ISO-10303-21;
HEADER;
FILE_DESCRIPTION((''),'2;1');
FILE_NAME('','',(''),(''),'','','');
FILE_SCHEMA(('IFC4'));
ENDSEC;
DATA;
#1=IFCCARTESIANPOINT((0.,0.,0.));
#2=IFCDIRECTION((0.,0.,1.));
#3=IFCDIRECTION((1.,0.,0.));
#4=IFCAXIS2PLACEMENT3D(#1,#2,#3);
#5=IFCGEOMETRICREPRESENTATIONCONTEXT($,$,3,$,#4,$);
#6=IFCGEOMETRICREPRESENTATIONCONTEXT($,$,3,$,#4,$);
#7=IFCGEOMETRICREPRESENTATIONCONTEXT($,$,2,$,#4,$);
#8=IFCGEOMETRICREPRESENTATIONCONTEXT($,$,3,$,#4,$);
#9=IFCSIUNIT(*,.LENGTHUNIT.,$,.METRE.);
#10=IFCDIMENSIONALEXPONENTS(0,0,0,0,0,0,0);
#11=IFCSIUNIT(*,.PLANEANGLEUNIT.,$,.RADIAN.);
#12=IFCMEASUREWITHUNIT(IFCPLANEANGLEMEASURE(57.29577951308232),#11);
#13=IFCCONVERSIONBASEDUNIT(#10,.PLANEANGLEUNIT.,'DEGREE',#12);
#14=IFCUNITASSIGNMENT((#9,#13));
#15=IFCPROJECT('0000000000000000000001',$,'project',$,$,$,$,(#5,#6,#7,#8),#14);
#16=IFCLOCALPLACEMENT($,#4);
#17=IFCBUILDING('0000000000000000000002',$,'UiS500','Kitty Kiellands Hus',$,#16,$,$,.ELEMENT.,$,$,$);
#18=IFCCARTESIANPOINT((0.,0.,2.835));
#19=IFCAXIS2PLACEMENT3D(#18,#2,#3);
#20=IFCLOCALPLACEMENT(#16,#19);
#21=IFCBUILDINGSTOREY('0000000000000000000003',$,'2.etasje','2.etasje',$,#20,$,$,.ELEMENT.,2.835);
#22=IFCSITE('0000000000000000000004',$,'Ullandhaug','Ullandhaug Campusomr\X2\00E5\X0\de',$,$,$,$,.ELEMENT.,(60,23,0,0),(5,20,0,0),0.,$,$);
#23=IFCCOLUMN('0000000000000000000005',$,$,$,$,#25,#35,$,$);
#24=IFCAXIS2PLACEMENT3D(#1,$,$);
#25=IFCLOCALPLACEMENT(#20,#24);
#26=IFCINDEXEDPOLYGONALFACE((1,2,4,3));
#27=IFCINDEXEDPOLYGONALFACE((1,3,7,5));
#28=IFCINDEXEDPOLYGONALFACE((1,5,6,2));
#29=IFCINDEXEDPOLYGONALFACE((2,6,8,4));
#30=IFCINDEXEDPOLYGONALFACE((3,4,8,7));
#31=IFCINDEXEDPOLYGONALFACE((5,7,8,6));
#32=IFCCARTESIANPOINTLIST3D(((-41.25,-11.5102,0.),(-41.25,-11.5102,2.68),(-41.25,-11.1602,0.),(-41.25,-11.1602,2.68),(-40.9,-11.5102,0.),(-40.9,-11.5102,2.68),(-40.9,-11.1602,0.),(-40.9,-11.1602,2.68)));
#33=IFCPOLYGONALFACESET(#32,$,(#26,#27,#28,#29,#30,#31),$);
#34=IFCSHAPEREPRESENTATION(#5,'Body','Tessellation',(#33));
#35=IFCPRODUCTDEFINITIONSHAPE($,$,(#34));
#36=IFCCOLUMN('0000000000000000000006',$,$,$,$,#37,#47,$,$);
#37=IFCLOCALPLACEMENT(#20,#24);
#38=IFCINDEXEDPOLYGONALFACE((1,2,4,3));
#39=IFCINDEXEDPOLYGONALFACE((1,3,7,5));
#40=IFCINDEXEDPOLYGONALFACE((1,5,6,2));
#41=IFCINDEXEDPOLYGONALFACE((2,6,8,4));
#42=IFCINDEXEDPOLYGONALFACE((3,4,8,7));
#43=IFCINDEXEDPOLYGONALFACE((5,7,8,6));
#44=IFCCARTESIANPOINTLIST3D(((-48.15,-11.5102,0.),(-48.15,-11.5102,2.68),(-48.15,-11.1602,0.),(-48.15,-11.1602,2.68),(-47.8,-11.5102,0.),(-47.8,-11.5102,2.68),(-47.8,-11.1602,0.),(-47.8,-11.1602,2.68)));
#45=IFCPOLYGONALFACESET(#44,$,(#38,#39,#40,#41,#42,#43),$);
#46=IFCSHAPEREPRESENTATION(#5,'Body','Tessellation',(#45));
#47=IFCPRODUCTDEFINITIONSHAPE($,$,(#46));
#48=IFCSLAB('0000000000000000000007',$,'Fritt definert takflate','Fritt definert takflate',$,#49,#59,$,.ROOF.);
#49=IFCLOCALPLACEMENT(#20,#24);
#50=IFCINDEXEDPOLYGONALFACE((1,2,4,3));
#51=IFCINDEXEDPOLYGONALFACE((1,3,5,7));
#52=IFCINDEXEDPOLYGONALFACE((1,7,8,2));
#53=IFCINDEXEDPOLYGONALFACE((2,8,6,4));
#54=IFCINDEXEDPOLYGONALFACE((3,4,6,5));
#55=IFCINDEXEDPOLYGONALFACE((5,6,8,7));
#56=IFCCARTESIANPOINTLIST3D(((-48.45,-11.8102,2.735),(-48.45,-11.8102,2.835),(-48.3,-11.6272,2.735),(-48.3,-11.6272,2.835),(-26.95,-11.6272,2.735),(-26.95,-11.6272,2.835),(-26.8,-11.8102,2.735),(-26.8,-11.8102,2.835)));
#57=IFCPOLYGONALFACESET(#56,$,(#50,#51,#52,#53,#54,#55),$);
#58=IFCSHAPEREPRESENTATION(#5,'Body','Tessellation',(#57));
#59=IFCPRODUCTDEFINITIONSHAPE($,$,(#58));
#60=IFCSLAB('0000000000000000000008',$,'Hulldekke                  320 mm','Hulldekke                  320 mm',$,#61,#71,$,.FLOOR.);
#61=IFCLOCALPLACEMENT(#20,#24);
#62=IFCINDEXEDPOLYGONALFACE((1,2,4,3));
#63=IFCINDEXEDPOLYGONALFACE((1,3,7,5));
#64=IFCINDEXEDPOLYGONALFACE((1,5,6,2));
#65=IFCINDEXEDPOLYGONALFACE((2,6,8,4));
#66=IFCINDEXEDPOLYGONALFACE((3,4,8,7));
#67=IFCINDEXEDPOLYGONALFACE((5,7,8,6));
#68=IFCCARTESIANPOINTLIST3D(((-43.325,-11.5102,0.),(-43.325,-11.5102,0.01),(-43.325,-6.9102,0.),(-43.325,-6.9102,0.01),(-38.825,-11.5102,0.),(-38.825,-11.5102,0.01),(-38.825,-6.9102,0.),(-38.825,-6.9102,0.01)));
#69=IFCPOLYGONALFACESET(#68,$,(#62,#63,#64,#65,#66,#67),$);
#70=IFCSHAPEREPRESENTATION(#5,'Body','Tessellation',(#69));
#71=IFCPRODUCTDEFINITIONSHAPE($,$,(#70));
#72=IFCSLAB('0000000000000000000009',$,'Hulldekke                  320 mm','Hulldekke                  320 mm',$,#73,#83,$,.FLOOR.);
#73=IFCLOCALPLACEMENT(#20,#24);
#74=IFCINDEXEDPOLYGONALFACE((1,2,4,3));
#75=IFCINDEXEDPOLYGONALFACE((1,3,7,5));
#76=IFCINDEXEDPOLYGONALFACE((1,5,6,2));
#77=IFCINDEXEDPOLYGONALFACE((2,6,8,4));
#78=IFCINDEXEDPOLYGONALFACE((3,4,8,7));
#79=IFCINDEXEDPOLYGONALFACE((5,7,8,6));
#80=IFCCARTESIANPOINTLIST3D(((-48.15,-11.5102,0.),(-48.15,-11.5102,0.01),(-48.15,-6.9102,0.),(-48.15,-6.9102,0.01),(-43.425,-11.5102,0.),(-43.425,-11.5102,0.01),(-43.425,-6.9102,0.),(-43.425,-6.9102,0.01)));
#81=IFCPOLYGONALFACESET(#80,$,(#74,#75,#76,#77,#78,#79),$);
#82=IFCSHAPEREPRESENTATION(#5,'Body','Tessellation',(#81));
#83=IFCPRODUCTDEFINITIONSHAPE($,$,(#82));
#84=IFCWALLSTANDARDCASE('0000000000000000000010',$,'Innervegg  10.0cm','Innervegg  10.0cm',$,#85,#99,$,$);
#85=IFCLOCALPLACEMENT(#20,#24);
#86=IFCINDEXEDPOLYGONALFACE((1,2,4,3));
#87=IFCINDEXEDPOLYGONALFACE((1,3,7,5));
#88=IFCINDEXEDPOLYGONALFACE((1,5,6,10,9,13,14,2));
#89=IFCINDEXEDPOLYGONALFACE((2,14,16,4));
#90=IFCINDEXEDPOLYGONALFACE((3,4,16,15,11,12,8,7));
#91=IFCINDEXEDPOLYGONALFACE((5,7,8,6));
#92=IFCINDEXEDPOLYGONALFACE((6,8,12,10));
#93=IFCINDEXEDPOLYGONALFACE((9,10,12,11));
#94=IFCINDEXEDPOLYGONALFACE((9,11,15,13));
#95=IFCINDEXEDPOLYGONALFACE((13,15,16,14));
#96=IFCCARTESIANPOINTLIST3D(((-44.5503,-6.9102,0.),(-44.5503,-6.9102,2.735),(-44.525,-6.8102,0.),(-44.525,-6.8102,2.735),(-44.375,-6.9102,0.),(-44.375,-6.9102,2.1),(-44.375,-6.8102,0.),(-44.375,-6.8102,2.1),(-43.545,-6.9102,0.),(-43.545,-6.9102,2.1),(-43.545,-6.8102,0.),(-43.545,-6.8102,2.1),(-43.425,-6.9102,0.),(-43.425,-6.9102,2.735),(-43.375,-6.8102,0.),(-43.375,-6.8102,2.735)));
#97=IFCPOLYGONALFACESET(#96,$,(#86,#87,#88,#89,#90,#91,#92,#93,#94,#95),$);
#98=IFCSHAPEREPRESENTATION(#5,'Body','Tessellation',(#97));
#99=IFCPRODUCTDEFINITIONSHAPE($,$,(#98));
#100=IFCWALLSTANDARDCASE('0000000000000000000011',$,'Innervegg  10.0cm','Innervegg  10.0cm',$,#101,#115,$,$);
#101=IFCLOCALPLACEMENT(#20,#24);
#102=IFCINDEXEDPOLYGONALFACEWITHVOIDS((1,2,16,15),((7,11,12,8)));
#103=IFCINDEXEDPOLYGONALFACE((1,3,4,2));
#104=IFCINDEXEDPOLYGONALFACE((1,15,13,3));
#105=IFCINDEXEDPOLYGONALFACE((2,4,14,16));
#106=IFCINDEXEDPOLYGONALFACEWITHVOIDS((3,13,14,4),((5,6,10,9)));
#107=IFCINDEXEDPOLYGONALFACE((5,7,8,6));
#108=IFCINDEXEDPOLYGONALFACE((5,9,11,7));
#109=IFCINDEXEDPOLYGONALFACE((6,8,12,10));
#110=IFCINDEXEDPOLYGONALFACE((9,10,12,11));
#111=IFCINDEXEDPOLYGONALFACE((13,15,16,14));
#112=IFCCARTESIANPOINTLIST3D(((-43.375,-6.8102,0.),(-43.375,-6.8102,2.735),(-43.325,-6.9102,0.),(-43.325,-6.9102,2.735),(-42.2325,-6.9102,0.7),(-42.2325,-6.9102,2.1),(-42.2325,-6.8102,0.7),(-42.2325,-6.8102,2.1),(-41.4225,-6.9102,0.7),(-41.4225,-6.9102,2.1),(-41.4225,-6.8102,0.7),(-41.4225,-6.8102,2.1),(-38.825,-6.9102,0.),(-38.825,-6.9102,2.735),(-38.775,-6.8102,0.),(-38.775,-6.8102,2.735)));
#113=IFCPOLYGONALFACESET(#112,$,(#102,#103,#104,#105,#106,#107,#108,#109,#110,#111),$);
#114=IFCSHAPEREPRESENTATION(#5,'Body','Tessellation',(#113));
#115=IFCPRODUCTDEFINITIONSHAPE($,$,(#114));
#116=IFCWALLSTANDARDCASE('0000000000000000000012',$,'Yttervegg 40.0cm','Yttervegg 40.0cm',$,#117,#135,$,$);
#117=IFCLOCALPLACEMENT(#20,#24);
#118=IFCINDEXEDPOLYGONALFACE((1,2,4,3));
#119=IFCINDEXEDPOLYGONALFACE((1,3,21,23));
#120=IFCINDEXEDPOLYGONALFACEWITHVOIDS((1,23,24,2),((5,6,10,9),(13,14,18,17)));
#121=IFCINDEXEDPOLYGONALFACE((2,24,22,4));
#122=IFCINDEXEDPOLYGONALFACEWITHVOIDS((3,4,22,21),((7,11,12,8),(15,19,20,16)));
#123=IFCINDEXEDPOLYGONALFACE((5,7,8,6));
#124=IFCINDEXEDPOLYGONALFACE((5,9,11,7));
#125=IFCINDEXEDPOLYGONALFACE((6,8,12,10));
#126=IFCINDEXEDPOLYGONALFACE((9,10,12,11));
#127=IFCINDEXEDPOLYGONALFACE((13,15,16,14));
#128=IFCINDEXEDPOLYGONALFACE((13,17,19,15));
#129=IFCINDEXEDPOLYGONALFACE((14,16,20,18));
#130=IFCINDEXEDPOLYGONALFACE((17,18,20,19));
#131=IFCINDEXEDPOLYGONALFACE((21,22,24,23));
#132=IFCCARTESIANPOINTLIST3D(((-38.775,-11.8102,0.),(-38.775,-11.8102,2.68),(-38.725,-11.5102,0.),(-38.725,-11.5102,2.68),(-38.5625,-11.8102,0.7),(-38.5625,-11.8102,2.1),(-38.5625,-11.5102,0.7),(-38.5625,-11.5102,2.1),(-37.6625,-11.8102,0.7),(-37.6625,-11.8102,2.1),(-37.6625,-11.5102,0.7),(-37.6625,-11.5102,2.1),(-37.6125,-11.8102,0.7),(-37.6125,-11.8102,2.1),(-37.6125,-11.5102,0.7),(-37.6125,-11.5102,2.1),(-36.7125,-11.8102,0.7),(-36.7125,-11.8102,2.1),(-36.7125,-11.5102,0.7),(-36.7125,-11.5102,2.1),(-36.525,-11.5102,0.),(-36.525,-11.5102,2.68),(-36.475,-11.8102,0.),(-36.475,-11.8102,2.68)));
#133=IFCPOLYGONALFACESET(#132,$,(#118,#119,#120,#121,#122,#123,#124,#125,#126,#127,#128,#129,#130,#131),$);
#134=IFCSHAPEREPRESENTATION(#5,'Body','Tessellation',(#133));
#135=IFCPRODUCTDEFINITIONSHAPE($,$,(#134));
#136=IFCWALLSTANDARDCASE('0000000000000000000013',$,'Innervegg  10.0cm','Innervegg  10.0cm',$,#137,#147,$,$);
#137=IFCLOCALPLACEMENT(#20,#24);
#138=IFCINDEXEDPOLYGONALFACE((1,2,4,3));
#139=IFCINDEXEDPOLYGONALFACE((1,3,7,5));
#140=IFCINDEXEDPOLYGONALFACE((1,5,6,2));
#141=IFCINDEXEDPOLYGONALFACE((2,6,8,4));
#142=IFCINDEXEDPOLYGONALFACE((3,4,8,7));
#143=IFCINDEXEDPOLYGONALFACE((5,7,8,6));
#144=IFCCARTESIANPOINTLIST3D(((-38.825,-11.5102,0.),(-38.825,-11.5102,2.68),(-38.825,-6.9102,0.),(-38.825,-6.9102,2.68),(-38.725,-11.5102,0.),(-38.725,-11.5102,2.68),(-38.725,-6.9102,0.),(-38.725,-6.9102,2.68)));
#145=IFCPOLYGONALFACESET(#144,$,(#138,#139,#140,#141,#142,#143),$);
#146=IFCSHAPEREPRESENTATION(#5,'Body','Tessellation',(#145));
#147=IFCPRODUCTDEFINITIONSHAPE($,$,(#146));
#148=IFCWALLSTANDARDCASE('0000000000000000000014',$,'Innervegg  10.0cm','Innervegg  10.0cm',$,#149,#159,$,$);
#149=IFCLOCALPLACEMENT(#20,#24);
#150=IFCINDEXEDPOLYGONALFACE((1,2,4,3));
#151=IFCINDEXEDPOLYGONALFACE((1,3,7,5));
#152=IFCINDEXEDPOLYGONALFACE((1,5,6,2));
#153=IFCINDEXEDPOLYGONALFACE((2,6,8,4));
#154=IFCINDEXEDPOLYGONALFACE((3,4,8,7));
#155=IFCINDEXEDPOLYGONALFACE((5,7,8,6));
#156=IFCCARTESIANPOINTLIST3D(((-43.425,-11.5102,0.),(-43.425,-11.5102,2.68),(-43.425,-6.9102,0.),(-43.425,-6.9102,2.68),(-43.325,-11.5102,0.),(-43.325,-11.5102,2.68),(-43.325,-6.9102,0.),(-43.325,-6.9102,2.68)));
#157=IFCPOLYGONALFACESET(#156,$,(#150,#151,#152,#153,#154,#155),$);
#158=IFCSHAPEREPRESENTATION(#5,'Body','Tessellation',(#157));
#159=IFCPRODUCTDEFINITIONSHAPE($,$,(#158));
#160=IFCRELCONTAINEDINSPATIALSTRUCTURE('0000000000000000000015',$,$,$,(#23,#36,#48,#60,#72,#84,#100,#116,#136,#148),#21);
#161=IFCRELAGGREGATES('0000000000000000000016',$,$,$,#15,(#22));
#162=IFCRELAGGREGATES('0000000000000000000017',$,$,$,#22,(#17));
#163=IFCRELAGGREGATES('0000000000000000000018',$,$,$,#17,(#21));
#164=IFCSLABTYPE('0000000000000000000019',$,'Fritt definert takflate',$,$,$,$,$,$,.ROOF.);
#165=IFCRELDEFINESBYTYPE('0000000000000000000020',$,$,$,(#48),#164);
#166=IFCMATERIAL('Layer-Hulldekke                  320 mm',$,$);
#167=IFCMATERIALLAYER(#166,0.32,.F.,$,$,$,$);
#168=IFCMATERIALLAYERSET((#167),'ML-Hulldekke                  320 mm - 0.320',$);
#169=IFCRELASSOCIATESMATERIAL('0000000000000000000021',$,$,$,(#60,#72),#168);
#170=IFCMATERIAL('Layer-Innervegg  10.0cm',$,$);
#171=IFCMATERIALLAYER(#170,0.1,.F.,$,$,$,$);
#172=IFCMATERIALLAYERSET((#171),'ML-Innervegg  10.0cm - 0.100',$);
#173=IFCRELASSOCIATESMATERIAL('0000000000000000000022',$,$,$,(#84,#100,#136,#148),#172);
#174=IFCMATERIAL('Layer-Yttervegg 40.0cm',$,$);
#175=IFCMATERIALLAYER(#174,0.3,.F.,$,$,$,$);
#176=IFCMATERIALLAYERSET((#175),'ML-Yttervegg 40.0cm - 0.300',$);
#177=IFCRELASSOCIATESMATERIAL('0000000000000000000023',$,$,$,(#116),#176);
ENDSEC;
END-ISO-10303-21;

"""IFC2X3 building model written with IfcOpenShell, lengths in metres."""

from ifc_helpers import new_model, entity, si_unit, converted_unit, frame, origin_with_axes, origin_2d_with_axis, place, context, project, spatial, polyline, rectangle, outline, extrude, material, layer, layer_set, layer_usage, type_object, element, save


model = new_model("IFC2X3")

# Units and contexts
context_of_model_1 = context(None, 3, world=origin_with_axes())
context_of_model_2 = context(None, 3, world=origin_with_axes())
context_of_model_3 = context(None, 2, world=origin_with_axes())
context_of_model_4 = context(None, 3, world=origin_with_axes())
ifc_project = project(units=[si_unit("LENGTHUNIT", "METRE"), converted_unit("PLANEANGLEUNIT", "DEGREE", entity("IfcPlaneAngleMeasure", 57.29577951308232), si_unit("PLANEANGLEUNIT", "RADIAN"), dimensions=[0, 0, 0, 0, 0, 0, 0])], contexts=[context_of_model_1, context_of_model_2, context_of_model_3, context_of_model_4])

# Site, building, storey
site = spatial("IfcSite", under=ifc_project, Name="Ullandhaug", Description="Ullandhaug Campusområde", CompositionType="ELEMENT", RefLatitude=(60, 23, 0, 0), RefLongitude=(5, 20, 0, 0), RefElevation=0.0)
building_placement = place(None, origin_with_axes())
building = spatial("IfcBuilding", under=site, at=building_placement, Name="UiS500", Description="Kitty Kiellands Hus", CompositionType="ELEMENT")
storey_placement = place(building_placement, frame((0.0, 0.0, 2.835), z_axis=(0.0, 0.0, 1.0), x_axis=(1.0, 0.0, 0.0)))
storey = spatial("IfcBuildingStorey", under=building, at=storey_placement, Name="2.etasje", Description="2.etasje", CompositionType="ELEMENT", Elevation=2.835)

# Columns
for number, where, z_axis, x_axis in (
    (1, (-41.075, -11.3352, 0.0), (0.0, 0.0, 1.0), (1.0, 0.0, 0.0)),
    (2, (-47.975, -11.3352, 0.0), (0.0, 0.0, 1.0), (1.0, 0.0, 0.0)),
):
    element("IfcColumn", number, at=place(storey_placement, frame(where, z_axis=z_axis, x_axis=x_axis)), inside=storey, context=context_of_model_1, shape_type="SweptSolid", body=[
        extrude(rectangle(XDim=0.35, YDim=0.35, at=origin_2d_with_axis()), origin_with_axes(), (0.0, 0.0, 1.0), 2.68),
    ])

# Slabs
slab_type = type_object("IfcSlabType", Name="Fritt definert takflate", PredefinedType="ROOF")
slab_1_placement = place(storey_placement, frame((-48.3, -11.6272, 2.735), z_axis=(0.0, 0.0, 1.0), x_axis=(-0.633931, -0.77339, 0.0)))
element("IfcSlab", 3, at=slab_1_placement, inside=storey, type_object=slab_type, Name="Fritt definert takflate", Description="Fritt definert takflate", PredefinedType="ROOF", context=context_of_model_1, shape_type="SweptSolid", body=[
    extrude(outline(polyline([(0.0, 0.0), (0.2366, 0.0), (-13.488, 16.7439), (-13.5344, 16.5119), (0.0, 0.0)])), origin_with_axes(), (0.0, 0.0, 1.0), 0.1),
])
ifc_material_1 = material(Name="Layer-Hulldekke                  320 mm")
ifc_layer_1 = layer(ifc_material_1, 0.32, ventilated=False)
ifc_layer_set_1 = layer_set([ifc_layer_1], Name="ML-Hulldekke                  320 mm - 0.320")
ifc_layer_usage_1 = layer_usage(ifc_layer_set_1, "AXIS2", "POSITIVE", 0.0)
slab_2_placement = place(storey_placement, frame((-43.325, -6.9102, 0.0), z_axis=(0.0, 0.0, 1.0), x_axis=(1.0, 0.0, 0.0)))
element("IfcSlab", 4, at=slab_2_placement, inside=storey, material=ifc_layer_usage_1, Name="Hulldekke                  320 mm", Description="Hulldekke                  320 mm", PredefinedType="FLOOR", context=context_of_model_1, shape_type="SweptSolid", body=[
    extrude(outline(polyline([(0.0, 0.0), (4.6, 0.0), (4.6, 4.5), (0.0, 4.5), (0.0, 0.0)])), frame((0.0, 0.0, 0.0), z_axis=(0.0, 0.0, 1.0), x_axis=(0.0, -1.0, 0.0)), (0.0, 0.0, 1.0), 0.01),
])
slab_3_placement = place(storey_placement, frame((-43.425, -6.9102, 0.0), z_axis=(0.0, 0.0, 1.0), x_axis=(1.0, 0.0, 0.0)))
element("IfcSlab", 5, at=slab_3_placement, inside=storey, material=ifc_layer_usage_1, Name="Hulldekke                  320 mm", Description="Hulldekke                  320 mm", PredefinedType="FLOOR", context=context_of_model_1, shape_type="SweptSolid", body=[
    extrude(outline(polyline([(0.0, 0.0), (4.725, 0.0), (4.725, 4.6), (0.0, 4.6), (0.0, 0.0)])), frame((0.0, 0.0, 0.0), z_axis=(0.0, 0.0, 1.0), x_axis=(-1.0, 0.0, 0.0)), (0.0, 0.0, 1.0), 0.01),
])

# Walls, openings
ifc_material_2 = material(Name="Layer-Innervegg  10.0cm")
ifc_layer_2 = layer(ifc_material_2, 0.1, ventilated=False)
ifc_layer_set_2 = layer_set([ifc_layer_2], Name="ML-Innervegg  10.0cm - 0.100")
ifc_layer_usage_2 = layer_usage(ifc_layer_set_2, "AXIS2", "POSITIVE", 0.0)
wall_1_placement = place(storey_placement, frame((-44.5503, -6.9102, 0.0), z_axis=(0.0, 0.0, 1.0), x_axis=(1.0, 0.0, 0.0)))
wall_1 = element("IfcWallStandardCase", 6, at=wall_1_placement, inside=storey, material=ifc_layer_usage_2, Name="Innervegg  10.0cm", Description="Innervegg  10.0cm", context=context_of_model_1, shape_type="SweptSolid", body=[
    extrude(outline(polyline([(0.0, 0.0), (1.1253, 0.0), (1.1753, 0.1), (0.0252, 0.1), (0.0, 0.0)])), origin_with_axes(), (0.0, 0.0, 1.0), 2.735),
])
opening_1_placement = place(wall_1_placement, frame((0.1753, 0.1, 0.0), z_axis=(0.0, 0.0, 1.0), x_axis=(1.0, 0.0, 0.0)))
element("IfcOpeningElement", 7, at=opening_1_placement, cuts=wall_1, context=context_of_model_1, shape_type="SweptSolid", body=[
    extrude(outline(polyline([(0.0, 0.0), (2.1, 0.0), (2.1, 0.83), (0.0, 0.83), (0.0, 0.0)])), frame((0.0, 0.0, 0.0), z_axis=(0.0, 1.0, 0.0), x_axis=(0.0, 0.0, 1.0)), (0.0, 0.0, -1.0), 0.1),
])
wall_2_placement = place(storey_placement, frame((-43.325, -6.9102, 0.0), z_axis=(0.0, 0.0, 1.0), x_axis=(1.0, 0.0, 0.0)))
wall_2 = element("IfcWallStandardCase", 8, at=wall_2_placement, inside=storey, material=ifc_layer_usage_2, Name="Innervegg  10.0cm", Description="Innervegg  10.0cm", context=context_of_model_1, shape_type="SweptSolid", body=[
    extrude(outline(polyline([(0.0, 0.0), (4.5, 0.0), (4.55, 0.1), (-0.05, 0.1), (0.0, 0.0)])), origin_with_axes(), (0.0, 0.0, 1.0), 2.735),
])
opening_2_placement = place(wall_2_placement, frame((1.0925, 0.1, 0.7), z_axis=(0.0, 0.0, 1.0), x_axis=(1.0, 0.0, 0.0)))
element("IfcOpeningElement", 9, at=opening_2_placement, cuts=wall_2, context=context_of_model_1, shape_type="SweptSolid", body=[
    extrude(outline(polyline([(0.0, 0.0), (1.4, 0.0), (1.4, 0.81), (0.0, 0.81), (0.0, 0.0)])), frame((0.0, 0.0, 0.0), z_axis=(0.0, 1.0, 0.0), x_axis=(0.0, 0.0, 1.0)), (0.0, 0.0, -1.0), 0.1),
])

# Wall, openings
ifc_material_3 = material(Name="Layer-Yttervegg 40.0cm")
ifc_layer_3 = layer(ifc_material_3, 0.3, ventilated=False)
ifc_layer_set_3 = layer_set([ifc_layer_3], Name="ML-Yttervegg 40.0cm - 0.300")
ifc_layer_usage_3 = layer_usage(ifc_layer_set_3, "AXIS2", "POSITIVE", 0.0)
wall_3_placement = place(storey_placement, frame((-38.775, -11.8102, 0.0), z_axis=(0.0, 0.0, 1.0), x_axis=(1.0, 0.0, 0.0)))
wall_3 = element("IfcWallStandardCase", 10, at=wall_3_placement, inside=storey, material=ifc_layer_usage_3, Name="Yttervegg 40.0cm", Description="Yttervegg 40.0cm", context=context_of_model_1, shape_type="SweptSolid", body=[
    extrude(outline(polyline([(0.0, 0.0), (2.3, 0.0), (2.25, 0.3), (0.05, 0.3), (0.0, 0.0)])), origin_with_axes(), (0.0, 0.0, 1.0), 2.68),
])
opening_3_placement = place(wall_3_placement, frame((1.1625, 0.3, 0.7), z_axis=(0.0, 0.0, 1.0), x_axis=(1.0, 0.0, 0.0)))
element("IfcOpeningElement", 11, at=opening_3_placement, cuts=wall_3, context=context_of_model_1, shape_type="SweptSolid", body=[
    extrude(outline(polyline([(0.0, 0.0), (1.4, 0.0), (1.4, 0.9), (0.0, 0.9), (0.0, 0.0)])), frame((0.0, 0.0, 0.0), z_axis=(0.0, 1.0, 0.0), x_axis=(0.0, 0.0, 1.0)), (0.0, 0.0, -1.0), 0.3),
])
opening_4_placement = place(wall_3_placement, frame((0.2125, 0.3, 0.7), z_axis=(0.0, 0.0, 1.0), x_axis=(1.0, 0.0, 0.0)))
element("IfcOpeningElement", 12, at=opening_4_placement, cuts=wall_3, context=context_of_model_1, shape_type="SweptSolid", body=[
    extrude(outline(polyline([(0.0, 0.0), (1.4, 0.0), (1.4, 0.9), (0.0, 0.9), (0.0, 0.0)])), frame((0.0, 0.0, 0.0), z_axis=(0.0, 1.0, 0.0), x_axis=(0.0, 0.0, 1.0)), (0.0, 0.0, -1.0), 0.3),
])

# Walls
wall_4_placement = place(storey_placement, frame((-38.825, -6.9102, 0.0), z_axis=(0.0, 0.0, 1.0), x_axis=(0.0, -1.0, 0.0)))
element("IfcWallStandardCase", 13, at=wall_4_placement, inside=storey, material=ifc_layer_usage_2, Name="Innervegg  10.0cm", Description="Innervegg  10.0cm", context=context_of_model_1, shape_type="SweptSolid", body=[
    extrude(outline(polyline([(0.0, 0.0), (4.6, 0.0), (4.6, 0.1), (0.0, 0.1), (0.0, 0.0)])), frame((0.0, 0.0, 0.0), z_axis=(0.0, 0.0, 1.0), x_axis=(1.0, 0.0, 0.0)), (0.0, 0.0, 1.0), 2.68),
])
wall_5_placement = place(storey_placement, frame((-43.425, -6.9102, 0.0), z_axis=(0.0, 0.0, 1.0), x_axis=(0.0, -1.0, 0.0)))
element("IfcWallStandardCase", 14, at=wall_5_placement, inside=storey, material=ifc_layer_usage_2, Name="Innervegg  10.0cm", Description="Innervegg  10.0cm", context=context_of_model_1, shape_type="SweptSolid", body=[
    extrude(outline(polyline([(0.0, 0.0), (4.6, 0.0), (4.6, 0.1), (0.0, 0.1), (0.0, 0.0)])), frame((0.0, 0.0, 0.0), z_axis=(0.0, 0.0, 1.0), x_axis=(1.0, 0.0, 0.0)), (0.0, 0.0, 1.0), 2.68),
])

save(model, "model.ifc")
